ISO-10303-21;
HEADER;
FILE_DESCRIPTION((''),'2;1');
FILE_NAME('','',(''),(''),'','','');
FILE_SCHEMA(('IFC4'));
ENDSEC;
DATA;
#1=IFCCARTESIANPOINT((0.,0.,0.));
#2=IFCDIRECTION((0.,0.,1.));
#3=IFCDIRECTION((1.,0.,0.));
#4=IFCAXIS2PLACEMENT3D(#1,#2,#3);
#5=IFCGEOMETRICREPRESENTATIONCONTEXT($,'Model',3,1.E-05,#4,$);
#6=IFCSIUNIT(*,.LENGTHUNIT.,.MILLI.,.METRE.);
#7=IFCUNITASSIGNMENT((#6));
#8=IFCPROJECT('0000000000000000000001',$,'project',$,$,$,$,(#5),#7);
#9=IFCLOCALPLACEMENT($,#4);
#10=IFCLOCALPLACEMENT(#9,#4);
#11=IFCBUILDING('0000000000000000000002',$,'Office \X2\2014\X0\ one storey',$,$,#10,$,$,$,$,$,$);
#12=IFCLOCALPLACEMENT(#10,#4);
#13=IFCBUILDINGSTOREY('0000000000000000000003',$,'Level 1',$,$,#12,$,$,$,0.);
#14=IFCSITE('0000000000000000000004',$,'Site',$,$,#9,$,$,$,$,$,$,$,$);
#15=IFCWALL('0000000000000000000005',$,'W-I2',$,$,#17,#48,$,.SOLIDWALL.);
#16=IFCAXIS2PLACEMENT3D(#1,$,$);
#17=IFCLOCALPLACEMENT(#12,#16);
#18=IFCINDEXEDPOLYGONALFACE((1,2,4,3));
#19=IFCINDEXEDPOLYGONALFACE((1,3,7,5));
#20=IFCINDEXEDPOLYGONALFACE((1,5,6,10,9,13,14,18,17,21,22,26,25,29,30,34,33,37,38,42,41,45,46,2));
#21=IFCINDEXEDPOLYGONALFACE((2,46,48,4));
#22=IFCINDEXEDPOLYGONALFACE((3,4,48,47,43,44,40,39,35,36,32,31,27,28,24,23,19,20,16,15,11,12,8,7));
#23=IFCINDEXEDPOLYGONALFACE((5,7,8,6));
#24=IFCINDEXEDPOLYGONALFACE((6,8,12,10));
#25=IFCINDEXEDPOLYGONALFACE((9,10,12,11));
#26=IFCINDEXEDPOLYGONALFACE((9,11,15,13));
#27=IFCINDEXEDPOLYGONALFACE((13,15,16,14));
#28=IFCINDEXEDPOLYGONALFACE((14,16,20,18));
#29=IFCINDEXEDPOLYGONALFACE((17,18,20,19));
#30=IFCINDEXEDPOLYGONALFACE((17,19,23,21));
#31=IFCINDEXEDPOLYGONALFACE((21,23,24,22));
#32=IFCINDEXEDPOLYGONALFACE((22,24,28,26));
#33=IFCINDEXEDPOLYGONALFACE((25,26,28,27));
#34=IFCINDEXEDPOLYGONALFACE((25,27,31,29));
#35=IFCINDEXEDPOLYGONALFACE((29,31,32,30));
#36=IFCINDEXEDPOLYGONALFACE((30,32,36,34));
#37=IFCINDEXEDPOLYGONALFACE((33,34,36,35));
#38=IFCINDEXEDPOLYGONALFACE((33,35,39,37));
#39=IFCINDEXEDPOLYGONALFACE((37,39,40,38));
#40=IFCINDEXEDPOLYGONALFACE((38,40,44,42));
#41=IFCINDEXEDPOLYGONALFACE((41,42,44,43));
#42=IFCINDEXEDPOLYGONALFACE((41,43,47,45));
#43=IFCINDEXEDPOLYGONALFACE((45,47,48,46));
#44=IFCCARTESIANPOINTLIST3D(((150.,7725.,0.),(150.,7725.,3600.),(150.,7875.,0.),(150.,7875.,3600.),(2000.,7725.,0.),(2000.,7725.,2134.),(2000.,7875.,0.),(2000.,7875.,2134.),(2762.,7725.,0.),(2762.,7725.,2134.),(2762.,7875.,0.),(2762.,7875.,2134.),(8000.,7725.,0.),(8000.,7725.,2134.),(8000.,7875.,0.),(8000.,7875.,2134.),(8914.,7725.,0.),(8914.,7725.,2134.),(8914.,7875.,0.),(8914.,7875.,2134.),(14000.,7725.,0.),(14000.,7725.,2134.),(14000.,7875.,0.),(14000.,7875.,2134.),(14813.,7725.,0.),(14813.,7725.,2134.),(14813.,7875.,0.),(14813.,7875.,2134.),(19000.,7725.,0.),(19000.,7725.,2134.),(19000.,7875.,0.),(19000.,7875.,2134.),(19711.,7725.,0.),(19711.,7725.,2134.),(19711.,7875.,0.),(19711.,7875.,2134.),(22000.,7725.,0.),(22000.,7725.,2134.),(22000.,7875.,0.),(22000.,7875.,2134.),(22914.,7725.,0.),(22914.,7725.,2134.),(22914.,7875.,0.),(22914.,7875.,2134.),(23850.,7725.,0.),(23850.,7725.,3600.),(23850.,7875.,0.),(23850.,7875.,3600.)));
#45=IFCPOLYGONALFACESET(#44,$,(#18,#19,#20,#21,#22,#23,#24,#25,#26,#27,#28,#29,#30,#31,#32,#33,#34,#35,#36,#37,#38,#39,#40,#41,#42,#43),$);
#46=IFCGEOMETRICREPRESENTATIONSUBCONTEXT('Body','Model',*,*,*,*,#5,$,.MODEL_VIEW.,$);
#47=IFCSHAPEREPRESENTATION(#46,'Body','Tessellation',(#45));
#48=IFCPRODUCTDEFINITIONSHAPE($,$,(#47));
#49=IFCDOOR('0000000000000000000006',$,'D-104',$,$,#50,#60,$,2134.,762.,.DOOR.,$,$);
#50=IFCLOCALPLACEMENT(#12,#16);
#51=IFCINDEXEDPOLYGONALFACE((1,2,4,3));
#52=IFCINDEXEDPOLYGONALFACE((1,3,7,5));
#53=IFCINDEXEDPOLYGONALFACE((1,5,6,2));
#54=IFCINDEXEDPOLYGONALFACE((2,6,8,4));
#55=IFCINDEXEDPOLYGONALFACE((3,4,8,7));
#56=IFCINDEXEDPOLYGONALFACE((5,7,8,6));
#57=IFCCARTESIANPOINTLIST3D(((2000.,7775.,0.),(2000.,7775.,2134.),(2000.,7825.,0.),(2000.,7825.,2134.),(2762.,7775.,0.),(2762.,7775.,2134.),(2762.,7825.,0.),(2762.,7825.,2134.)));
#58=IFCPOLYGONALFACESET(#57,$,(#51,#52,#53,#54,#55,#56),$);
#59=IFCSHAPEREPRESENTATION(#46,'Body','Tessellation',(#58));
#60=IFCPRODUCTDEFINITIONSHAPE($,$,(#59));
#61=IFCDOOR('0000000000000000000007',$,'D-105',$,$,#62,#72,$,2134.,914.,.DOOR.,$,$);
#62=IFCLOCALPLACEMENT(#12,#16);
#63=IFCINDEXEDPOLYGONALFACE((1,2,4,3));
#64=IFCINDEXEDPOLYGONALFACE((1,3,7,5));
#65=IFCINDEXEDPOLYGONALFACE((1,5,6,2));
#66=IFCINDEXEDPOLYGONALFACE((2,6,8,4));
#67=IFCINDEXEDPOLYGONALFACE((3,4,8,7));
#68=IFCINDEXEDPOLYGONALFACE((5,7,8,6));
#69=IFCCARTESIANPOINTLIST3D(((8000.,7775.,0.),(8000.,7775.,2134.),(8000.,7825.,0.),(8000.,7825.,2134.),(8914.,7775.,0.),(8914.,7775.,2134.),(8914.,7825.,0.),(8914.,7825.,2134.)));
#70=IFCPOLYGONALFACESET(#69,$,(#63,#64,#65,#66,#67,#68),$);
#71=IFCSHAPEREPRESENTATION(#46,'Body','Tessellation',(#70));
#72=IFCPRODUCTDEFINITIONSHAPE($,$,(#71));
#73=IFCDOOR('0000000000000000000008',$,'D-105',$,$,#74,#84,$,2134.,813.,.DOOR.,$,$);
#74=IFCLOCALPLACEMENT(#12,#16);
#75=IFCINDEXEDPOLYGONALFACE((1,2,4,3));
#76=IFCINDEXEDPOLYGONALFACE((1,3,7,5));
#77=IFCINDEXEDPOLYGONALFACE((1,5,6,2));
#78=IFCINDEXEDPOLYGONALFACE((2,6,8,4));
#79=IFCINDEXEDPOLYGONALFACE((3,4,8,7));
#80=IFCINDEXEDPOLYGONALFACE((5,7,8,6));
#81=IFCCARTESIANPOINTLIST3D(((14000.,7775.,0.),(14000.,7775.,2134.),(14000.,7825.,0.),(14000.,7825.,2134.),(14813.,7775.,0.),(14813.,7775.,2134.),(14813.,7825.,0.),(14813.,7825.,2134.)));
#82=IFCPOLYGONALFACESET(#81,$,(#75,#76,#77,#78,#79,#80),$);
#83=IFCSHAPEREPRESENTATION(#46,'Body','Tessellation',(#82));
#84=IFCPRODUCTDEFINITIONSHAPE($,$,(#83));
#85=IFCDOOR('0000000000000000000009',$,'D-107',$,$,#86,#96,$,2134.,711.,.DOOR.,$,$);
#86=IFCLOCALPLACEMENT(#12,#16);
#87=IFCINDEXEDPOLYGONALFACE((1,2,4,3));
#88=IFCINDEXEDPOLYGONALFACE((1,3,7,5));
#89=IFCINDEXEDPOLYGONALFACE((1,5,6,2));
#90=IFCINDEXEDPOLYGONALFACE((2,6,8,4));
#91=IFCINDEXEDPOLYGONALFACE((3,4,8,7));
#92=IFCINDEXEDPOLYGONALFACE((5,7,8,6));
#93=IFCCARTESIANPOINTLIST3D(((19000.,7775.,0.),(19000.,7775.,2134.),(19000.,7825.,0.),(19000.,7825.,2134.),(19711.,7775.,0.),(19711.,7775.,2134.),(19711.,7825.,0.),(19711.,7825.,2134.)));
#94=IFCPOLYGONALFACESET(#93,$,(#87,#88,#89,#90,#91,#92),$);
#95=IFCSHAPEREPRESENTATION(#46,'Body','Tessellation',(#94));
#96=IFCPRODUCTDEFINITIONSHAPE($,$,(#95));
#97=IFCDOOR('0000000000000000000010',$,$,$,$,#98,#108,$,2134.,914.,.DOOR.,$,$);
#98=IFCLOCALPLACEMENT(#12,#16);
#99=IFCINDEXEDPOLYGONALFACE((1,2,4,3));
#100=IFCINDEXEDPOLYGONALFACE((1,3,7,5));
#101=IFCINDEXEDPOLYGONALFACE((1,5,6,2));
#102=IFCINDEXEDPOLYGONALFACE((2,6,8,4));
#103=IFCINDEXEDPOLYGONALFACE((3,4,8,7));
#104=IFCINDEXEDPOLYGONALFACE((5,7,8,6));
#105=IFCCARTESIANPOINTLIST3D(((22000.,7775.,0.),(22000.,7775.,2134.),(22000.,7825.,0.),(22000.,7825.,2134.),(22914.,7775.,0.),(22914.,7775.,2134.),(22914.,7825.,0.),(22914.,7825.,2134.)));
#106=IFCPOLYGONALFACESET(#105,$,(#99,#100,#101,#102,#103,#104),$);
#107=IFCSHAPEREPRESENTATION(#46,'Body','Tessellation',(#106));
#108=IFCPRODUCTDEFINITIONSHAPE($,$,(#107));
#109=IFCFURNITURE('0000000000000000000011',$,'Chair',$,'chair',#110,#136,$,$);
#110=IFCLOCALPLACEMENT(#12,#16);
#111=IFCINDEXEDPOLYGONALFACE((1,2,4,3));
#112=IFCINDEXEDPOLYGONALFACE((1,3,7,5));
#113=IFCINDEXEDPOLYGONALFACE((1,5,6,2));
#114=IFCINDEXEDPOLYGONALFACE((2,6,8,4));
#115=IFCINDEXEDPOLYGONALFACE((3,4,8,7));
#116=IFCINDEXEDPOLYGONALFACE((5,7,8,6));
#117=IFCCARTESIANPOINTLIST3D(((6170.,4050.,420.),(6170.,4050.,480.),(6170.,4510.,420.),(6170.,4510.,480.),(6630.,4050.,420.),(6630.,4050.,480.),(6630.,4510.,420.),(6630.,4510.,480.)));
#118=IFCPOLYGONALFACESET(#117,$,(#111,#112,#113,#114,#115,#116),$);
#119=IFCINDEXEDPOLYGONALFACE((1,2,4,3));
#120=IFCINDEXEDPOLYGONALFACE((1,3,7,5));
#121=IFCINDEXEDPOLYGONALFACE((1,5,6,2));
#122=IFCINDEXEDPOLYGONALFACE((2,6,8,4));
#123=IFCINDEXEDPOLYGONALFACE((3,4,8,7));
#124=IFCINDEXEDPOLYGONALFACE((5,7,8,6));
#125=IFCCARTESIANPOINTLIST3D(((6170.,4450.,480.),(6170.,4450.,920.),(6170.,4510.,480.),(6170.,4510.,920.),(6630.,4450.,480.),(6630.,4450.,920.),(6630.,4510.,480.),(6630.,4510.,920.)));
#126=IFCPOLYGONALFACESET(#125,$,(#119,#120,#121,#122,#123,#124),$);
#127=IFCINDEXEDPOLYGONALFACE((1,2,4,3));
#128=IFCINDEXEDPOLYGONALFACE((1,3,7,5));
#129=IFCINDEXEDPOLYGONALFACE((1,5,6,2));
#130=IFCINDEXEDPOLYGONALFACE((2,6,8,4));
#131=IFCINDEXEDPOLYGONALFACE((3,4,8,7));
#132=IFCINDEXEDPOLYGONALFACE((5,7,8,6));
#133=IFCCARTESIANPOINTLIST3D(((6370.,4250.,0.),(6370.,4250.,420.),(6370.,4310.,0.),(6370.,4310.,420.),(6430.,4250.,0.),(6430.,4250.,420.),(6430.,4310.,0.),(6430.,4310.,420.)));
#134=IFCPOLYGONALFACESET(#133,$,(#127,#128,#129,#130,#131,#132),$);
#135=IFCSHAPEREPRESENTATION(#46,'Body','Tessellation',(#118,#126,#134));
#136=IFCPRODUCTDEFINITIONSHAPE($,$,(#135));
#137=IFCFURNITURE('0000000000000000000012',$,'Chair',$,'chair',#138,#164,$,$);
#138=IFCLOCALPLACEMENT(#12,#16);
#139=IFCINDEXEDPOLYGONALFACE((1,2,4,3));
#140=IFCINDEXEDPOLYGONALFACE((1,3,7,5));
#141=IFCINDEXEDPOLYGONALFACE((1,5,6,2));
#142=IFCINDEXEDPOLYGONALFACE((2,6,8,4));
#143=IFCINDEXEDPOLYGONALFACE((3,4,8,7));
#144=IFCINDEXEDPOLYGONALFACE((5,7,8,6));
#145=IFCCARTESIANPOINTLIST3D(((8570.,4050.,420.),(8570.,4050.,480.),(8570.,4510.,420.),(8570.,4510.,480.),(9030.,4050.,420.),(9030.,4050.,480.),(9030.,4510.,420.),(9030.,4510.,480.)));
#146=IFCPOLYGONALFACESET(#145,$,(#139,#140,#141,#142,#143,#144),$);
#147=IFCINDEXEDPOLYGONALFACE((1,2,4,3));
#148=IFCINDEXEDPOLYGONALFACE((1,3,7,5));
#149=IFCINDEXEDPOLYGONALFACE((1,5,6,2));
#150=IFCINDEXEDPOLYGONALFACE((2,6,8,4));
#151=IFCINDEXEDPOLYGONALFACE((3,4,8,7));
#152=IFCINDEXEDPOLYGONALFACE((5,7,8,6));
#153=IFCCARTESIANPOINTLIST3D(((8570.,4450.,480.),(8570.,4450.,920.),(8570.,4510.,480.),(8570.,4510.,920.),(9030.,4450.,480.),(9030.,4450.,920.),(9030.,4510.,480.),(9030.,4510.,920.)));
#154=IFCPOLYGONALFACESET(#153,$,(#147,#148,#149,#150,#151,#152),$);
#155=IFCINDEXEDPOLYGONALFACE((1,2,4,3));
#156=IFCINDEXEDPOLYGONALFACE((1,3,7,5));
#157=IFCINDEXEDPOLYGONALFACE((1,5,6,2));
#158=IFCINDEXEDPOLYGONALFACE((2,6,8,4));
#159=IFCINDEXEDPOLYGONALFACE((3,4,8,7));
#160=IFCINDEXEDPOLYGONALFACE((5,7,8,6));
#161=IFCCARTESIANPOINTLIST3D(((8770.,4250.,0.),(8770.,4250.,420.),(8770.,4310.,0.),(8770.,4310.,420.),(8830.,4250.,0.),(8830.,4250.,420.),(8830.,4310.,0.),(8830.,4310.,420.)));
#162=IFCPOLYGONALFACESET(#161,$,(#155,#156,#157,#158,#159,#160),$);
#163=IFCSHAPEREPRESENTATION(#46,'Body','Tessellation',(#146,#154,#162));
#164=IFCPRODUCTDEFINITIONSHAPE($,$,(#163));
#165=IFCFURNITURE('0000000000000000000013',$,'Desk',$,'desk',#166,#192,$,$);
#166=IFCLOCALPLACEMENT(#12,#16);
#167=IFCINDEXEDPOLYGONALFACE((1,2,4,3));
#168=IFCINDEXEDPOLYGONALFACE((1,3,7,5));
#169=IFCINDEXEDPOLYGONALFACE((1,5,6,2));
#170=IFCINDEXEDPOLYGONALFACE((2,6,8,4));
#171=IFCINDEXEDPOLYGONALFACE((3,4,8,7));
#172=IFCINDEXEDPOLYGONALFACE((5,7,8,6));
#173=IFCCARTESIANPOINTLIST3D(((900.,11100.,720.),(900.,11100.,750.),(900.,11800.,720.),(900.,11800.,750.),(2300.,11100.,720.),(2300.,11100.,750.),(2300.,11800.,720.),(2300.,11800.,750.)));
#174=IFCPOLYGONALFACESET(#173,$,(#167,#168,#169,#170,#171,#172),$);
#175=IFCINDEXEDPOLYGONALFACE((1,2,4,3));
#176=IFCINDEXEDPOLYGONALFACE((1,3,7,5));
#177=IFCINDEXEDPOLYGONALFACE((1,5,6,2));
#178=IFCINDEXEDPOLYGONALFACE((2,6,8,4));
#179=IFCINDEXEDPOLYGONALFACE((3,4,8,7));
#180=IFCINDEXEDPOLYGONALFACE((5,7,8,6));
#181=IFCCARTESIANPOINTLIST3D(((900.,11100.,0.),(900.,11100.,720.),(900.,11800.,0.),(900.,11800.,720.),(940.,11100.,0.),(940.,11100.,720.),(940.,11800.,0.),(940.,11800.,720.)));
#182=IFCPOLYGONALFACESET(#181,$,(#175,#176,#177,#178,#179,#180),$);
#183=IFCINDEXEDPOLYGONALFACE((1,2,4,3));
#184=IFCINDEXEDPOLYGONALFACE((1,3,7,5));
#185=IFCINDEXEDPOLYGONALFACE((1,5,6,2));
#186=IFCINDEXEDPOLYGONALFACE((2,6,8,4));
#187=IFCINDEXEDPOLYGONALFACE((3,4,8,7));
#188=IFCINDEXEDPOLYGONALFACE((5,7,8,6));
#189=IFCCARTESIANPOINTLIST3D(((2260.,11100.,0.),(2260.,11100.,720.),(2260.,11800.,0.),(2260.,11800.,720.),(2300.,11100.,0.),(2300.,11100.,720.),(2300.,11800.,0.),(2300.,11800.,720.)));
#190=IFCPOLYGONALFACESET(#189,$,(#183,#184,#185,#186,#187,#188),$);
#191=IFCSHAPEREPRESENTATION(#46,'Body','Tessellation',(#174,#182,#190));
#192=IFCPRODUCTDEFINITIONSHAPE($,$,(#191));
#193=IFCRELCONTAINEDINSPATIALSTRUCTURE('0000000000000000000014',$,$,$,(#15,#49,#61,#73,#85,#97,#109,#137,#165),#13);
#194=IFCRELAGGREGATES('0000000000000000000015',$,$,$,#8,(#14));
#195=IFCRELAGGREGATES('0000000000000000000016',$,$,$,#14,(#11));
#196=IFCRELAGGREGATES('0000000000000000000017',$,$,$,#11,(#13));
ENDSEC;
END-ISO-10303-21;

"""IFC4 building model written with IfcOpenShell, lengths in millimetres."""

from ifc_helpers import new_model, si_unit, frame, frame_2d, origin, origin_with_axes, place, context, subcontext, project, spatial, rectangle, extrude, element, fill, save


model = new_model("IFC4")

# Units and contexts
model_context = context("Model", 3, precision=1e-05, world=origin_with_axes())
body_context = subcontext(model_context, "Body", "Model", "MODEL_VIEW")
ifc_project = project(units=[si_unit("LENGTHUNIT", "METRE", prefix="MILLI")], contexts=[model_context])

# Site, building, storey
site_placement = place(None, origin_with_axes())
site = spatial("IfcSite", under=ifc_project, at=site_placement, Name="Site")
building_placement = place(site_placement, origin_with_axes())
building = spatial("IfcBuilding", under=site, at=building_placement, Name="Office — one storey")
storey_placement = place(building_placement, origin_with_axes())
storey = spatial("IfcBuildingStorey", under=building, at=storey_placement, Name="Level 1", Elevation=0.0)

# Wall, openings, doors
wall_1_placement = place(storey_placement, frame((0.0, 7725.0, 0.0), z_axis=(0.0, 0.0, 1.0), x_axis=(1.0, 0.0, 0.0)))
wall_1 = element("IfcWall", 1, at=wall_1_placement, inside=storey, Name="W-I2", PredefinedType="SOLIDWALL", context=body_context, shape_type="SweptSolid", body=[
    extrude(rectangle(XDim=23700.0, YDim=150.0, at=frame_2d((12000.0, 75.0))), origin(), (0.0, 0.0, 1.0), 3600.0),
])
opening_1_placement = place(wall_1_placement, frame((2000.0, -10.0, 0.0), z_axis=(0.0, 0.0, 1.0), x_axis=(1.0, 0.0, 0.0)))
opening_1 = element("IfcOpeningElement", 2, at=opening_1_placement, cuts=wall_1, context=body_context, shape_type="SweptSolid", body=[
    extrude(rectangle(XDim=762.0, YDim=170.0, at=frame_2d((381.0, 85.0))), origin(), (0.0, 0.0, 1.0), 2134.0),
])
opening_2_placement = place(wall_1_placement, frame((8000.0, -10.0, 0.0), z_axis=(0.0, 0.0, 1.0), x_axis=(1.0, 0.0, 0.0)))
opening_2 = element("IfcOpeningElement", 3, at=opening_2_placement, cuts=wall_1, context=body_context, shape_type="SweptSolid", body=[
    extrude(rectangle(XDim=914.0, YDim=170.0, at=frame_2d((457.0, 85.0))), origin(), (0.0, 0.0, 1.0), 2134.0),
])
opening_3_placement = place(wall_1_placement, frame((14000.0, -10.0, 0.0), z_axis=(0.0, 0.0, 1.0), x_axis=(1.0, 0.0, 0.0)))
opening_3 = element("IfcOpeningElement", 4, at=opening_3_placement, cuts=wall_1, context=body_context, shape_type="SweptSolid", body=[
    extrude(rectangle(XDim=813.0, YDim=170.0, at=frame_2d((406.5, 85.0))), origin(), (0.0, 0.0, 1.0), 2134.0),
])
opening_4_placement = place(wall_1_placement, frame((19000.0, -10.0, 0.0), z_axis=(0.0, 0.0, 1.0), x_axis=(1.0, 0.0, 0.0)))
opening_4 = element("IfcOpeningElement", 5, at=opening_4_placement, cuts=wall_1, context=body_context, shape_type="SweptSolid", body=[
    extrude(rectangle(XDim=711.0, YDim=170.0, at=frame_2d((355.5, 85.0))), origin(), (0.0, 0.0, 1.0), 2134.0),
])
opening_5_placement = place(wall_1_placement, frame((22000.0, -10.0, 0.0), z_axis=(0.0, 0.0, 1.0), x_axis=(1.0, 0.0, 0.0)))
opening_5 = element("IfcOpeningElement", 6, at=opening_5_placement, cuts=wall_1, context=body_context, shape_type="SweptSolid", body=[
    extrude(rectangle(XDim=914.0, YDim=170.0, at=frame_2d((457.0, 85.0))), origin(), (0.0, 0.0, 1.0), 2134.0),
])
door_1_placement = place(storey_placement, frame((2000.0, 7775.0, 0.0), z_axis=(0.0, 0.0, 1.0), x_axis=(1.0, 0.0, 0.0)))
door_1 = element("IfcDoor", 7, at=door_1_placement, inside=storey, Name="D-104", OverallHeight=2134.0, OverallWidth=762.0, PredefinedType="DOOR", context=body_context, shape_type="SweptSolid", body=[
    extrude(rectangle(XDim=762.0, YDim=50.0, at=frame_2d((381.0, 25.0))), origin(), (0.0, 0.0, 1.0), 2134.0),
])
fill(opening_1, door_1)
door_2_placement = place(storey_placement, frame((8000.0, 7775.0, 0.0), z_axis=(0.0, 0.0, 1.0), x_axis=(1.0, 0.0, 0.0)))
door_2 = element("IfcDoor", 8, at=door_2_placement, inside=storey, Name="D-105", OverallHeight=2134.0, OverallWidth=914.0, PredefinedType="DOOR", context=body_context, shape_type="SweptSolid", body=[
    extrude(rectangle(XDim=914.0, YDim=50.0, at=frame_2d((457.0, 25.0))), origin(), (0.0, 0.0, 1.0), 2134.0),
])
fill(opening_2, door_2)
door_3_placement = place(storey_placement, frame((14000.0, 7775.0, 0.0), z_axis=(0.0, 0.0, 1.0), x_axis=(1.0, 0.0, 0.0)))
door_3 = element("IfcDoor", 9, at=door_3_placement, inside=storey, Name="D-105", OverallHeight=2134.0, OverallWidth=813.0, PredefinedType="DOOR", context=body_context, shape_type="SweptSolid", body=[
    extrude(rectangle(XDim=813.0, YDim=50.0, at=frame_2d((406.5, 25.0))), origin(), (0.0, 0.0, 1.0), 2134.0),
])
fill(opening_3, door_3)
door_4_placement = place(storey_placement, frame((19000.0, 7775.0, 0.0), z_axis=(0.0, 0.0, 1.0), x_axis=(1.0, 0.0, 0.0)))
door_4 = element("IfcDoor", 10, at=door_4_placement, inside=storey, Name="D-107", OverallHeight=2134.0, OverallWidth=711.0, PredefinedType="DOOR", context=body_context, shape_type="SweptSolid", body=[
    extrude(rectangle(XDim=711.0, YDim=50.0, at=frame_2d((355.5, 25.0))), origin(), (0.0, 0.0, 1.0), 2134.0),
])
fill(opening_4, door_4)
door_5_placement = place(storey_placement, frame((22000.0, 7775.0, 0.0), z_axis=(0.0, 0.0, 1.0), x_axis=(1.0, 0.0, 0.0)))
door_5 = element("IfcDoor", 11, at=door_5_placement, inside=storey, OverallHeight=2134.0, OverallWidth=914.0, PredefinedType="DOOR", context=body_context, shape_type="SweptSolid", body=[
    extrude(rectangle(XDim=914.0, YDim=50.0, at=frame_2d((457.0, 25.0))), origin(), (0.0, 0.0, 1.0), 2134.0),
])
fill(opening_5, door_5)

# Furniture
for number, where, z_axis, x_axis, name in (
    (12, (6170.0, 4050.0, 0.0), (0.0, 0.0, 1.0), (1.0, 0.0, 0.0), "Chair"),
    (13, (8570.0, 4050.0, 0.0), (0.0, 0.0, 1.0), (1.0, 0.0, 0.0), "Chair"),
):
    element("IfcFurniture", number, at=place(storey_placement, frame(where, z_axis=z_axis, x_axis=x_axis)), inside=storey, Name=name, ObjectType="chair", context=body_context, shape_type="SweptSolid", body=[
        extrude(rectangle(XDim=460.0, YDim=460.0, at=frame_2d((230.0, 230.0))), frame((0.0, 0.0, 420.0)), (0.0, 0.0, 1.0), 60.0),
        extrude(rectangle(XDim=460.0, YDim=60.0, at=frame_2d((230.0, 430.0))), frame((0.0, 0.0, 480.0)), (0.0, 0.0, 1.0), 440.0),
        extrude(rectangle(XDim=60.0, YDim=60.0, at=frame_2d((230.0, 230.0))), origin(), (0.0, 0.0, 1.0), 420.0),
    ])
furniture_placement = place(storey_placement, frame((900.0, 11100.0, 0.0), z_axis=(0.0, 0.0, 1.0), x_axis=(1.0, 0.0, 0.0)))
element("IfcFurniture", 14, at=furniture_placement, inside=storey, Name="Desk", ObjectType="desk", context=body_context, shape_type="SweptSolid", body=[
    extrude(rectangle(XDim=1400.0, YDim=700.0, at=frame_2d((700.0, 350.0))), frame((0.0, 0.0, 720.0)), (0.0, 0.0, 1.0), 30.0),
    extrude(rectangle(XDim=40.0, YDim=700.0, at=frame_2d((20.0, 350.0))), origin(), (0.0, 0.0, 1.0), 720.0),
    extrude(rectangle(XDim=40.0, YDim=700.0, at=frame_2d((1380.0, 350.0))), origin(), (0.0, 0.0, 1.0), 720.0),
])

save(model, "model.ifc")
